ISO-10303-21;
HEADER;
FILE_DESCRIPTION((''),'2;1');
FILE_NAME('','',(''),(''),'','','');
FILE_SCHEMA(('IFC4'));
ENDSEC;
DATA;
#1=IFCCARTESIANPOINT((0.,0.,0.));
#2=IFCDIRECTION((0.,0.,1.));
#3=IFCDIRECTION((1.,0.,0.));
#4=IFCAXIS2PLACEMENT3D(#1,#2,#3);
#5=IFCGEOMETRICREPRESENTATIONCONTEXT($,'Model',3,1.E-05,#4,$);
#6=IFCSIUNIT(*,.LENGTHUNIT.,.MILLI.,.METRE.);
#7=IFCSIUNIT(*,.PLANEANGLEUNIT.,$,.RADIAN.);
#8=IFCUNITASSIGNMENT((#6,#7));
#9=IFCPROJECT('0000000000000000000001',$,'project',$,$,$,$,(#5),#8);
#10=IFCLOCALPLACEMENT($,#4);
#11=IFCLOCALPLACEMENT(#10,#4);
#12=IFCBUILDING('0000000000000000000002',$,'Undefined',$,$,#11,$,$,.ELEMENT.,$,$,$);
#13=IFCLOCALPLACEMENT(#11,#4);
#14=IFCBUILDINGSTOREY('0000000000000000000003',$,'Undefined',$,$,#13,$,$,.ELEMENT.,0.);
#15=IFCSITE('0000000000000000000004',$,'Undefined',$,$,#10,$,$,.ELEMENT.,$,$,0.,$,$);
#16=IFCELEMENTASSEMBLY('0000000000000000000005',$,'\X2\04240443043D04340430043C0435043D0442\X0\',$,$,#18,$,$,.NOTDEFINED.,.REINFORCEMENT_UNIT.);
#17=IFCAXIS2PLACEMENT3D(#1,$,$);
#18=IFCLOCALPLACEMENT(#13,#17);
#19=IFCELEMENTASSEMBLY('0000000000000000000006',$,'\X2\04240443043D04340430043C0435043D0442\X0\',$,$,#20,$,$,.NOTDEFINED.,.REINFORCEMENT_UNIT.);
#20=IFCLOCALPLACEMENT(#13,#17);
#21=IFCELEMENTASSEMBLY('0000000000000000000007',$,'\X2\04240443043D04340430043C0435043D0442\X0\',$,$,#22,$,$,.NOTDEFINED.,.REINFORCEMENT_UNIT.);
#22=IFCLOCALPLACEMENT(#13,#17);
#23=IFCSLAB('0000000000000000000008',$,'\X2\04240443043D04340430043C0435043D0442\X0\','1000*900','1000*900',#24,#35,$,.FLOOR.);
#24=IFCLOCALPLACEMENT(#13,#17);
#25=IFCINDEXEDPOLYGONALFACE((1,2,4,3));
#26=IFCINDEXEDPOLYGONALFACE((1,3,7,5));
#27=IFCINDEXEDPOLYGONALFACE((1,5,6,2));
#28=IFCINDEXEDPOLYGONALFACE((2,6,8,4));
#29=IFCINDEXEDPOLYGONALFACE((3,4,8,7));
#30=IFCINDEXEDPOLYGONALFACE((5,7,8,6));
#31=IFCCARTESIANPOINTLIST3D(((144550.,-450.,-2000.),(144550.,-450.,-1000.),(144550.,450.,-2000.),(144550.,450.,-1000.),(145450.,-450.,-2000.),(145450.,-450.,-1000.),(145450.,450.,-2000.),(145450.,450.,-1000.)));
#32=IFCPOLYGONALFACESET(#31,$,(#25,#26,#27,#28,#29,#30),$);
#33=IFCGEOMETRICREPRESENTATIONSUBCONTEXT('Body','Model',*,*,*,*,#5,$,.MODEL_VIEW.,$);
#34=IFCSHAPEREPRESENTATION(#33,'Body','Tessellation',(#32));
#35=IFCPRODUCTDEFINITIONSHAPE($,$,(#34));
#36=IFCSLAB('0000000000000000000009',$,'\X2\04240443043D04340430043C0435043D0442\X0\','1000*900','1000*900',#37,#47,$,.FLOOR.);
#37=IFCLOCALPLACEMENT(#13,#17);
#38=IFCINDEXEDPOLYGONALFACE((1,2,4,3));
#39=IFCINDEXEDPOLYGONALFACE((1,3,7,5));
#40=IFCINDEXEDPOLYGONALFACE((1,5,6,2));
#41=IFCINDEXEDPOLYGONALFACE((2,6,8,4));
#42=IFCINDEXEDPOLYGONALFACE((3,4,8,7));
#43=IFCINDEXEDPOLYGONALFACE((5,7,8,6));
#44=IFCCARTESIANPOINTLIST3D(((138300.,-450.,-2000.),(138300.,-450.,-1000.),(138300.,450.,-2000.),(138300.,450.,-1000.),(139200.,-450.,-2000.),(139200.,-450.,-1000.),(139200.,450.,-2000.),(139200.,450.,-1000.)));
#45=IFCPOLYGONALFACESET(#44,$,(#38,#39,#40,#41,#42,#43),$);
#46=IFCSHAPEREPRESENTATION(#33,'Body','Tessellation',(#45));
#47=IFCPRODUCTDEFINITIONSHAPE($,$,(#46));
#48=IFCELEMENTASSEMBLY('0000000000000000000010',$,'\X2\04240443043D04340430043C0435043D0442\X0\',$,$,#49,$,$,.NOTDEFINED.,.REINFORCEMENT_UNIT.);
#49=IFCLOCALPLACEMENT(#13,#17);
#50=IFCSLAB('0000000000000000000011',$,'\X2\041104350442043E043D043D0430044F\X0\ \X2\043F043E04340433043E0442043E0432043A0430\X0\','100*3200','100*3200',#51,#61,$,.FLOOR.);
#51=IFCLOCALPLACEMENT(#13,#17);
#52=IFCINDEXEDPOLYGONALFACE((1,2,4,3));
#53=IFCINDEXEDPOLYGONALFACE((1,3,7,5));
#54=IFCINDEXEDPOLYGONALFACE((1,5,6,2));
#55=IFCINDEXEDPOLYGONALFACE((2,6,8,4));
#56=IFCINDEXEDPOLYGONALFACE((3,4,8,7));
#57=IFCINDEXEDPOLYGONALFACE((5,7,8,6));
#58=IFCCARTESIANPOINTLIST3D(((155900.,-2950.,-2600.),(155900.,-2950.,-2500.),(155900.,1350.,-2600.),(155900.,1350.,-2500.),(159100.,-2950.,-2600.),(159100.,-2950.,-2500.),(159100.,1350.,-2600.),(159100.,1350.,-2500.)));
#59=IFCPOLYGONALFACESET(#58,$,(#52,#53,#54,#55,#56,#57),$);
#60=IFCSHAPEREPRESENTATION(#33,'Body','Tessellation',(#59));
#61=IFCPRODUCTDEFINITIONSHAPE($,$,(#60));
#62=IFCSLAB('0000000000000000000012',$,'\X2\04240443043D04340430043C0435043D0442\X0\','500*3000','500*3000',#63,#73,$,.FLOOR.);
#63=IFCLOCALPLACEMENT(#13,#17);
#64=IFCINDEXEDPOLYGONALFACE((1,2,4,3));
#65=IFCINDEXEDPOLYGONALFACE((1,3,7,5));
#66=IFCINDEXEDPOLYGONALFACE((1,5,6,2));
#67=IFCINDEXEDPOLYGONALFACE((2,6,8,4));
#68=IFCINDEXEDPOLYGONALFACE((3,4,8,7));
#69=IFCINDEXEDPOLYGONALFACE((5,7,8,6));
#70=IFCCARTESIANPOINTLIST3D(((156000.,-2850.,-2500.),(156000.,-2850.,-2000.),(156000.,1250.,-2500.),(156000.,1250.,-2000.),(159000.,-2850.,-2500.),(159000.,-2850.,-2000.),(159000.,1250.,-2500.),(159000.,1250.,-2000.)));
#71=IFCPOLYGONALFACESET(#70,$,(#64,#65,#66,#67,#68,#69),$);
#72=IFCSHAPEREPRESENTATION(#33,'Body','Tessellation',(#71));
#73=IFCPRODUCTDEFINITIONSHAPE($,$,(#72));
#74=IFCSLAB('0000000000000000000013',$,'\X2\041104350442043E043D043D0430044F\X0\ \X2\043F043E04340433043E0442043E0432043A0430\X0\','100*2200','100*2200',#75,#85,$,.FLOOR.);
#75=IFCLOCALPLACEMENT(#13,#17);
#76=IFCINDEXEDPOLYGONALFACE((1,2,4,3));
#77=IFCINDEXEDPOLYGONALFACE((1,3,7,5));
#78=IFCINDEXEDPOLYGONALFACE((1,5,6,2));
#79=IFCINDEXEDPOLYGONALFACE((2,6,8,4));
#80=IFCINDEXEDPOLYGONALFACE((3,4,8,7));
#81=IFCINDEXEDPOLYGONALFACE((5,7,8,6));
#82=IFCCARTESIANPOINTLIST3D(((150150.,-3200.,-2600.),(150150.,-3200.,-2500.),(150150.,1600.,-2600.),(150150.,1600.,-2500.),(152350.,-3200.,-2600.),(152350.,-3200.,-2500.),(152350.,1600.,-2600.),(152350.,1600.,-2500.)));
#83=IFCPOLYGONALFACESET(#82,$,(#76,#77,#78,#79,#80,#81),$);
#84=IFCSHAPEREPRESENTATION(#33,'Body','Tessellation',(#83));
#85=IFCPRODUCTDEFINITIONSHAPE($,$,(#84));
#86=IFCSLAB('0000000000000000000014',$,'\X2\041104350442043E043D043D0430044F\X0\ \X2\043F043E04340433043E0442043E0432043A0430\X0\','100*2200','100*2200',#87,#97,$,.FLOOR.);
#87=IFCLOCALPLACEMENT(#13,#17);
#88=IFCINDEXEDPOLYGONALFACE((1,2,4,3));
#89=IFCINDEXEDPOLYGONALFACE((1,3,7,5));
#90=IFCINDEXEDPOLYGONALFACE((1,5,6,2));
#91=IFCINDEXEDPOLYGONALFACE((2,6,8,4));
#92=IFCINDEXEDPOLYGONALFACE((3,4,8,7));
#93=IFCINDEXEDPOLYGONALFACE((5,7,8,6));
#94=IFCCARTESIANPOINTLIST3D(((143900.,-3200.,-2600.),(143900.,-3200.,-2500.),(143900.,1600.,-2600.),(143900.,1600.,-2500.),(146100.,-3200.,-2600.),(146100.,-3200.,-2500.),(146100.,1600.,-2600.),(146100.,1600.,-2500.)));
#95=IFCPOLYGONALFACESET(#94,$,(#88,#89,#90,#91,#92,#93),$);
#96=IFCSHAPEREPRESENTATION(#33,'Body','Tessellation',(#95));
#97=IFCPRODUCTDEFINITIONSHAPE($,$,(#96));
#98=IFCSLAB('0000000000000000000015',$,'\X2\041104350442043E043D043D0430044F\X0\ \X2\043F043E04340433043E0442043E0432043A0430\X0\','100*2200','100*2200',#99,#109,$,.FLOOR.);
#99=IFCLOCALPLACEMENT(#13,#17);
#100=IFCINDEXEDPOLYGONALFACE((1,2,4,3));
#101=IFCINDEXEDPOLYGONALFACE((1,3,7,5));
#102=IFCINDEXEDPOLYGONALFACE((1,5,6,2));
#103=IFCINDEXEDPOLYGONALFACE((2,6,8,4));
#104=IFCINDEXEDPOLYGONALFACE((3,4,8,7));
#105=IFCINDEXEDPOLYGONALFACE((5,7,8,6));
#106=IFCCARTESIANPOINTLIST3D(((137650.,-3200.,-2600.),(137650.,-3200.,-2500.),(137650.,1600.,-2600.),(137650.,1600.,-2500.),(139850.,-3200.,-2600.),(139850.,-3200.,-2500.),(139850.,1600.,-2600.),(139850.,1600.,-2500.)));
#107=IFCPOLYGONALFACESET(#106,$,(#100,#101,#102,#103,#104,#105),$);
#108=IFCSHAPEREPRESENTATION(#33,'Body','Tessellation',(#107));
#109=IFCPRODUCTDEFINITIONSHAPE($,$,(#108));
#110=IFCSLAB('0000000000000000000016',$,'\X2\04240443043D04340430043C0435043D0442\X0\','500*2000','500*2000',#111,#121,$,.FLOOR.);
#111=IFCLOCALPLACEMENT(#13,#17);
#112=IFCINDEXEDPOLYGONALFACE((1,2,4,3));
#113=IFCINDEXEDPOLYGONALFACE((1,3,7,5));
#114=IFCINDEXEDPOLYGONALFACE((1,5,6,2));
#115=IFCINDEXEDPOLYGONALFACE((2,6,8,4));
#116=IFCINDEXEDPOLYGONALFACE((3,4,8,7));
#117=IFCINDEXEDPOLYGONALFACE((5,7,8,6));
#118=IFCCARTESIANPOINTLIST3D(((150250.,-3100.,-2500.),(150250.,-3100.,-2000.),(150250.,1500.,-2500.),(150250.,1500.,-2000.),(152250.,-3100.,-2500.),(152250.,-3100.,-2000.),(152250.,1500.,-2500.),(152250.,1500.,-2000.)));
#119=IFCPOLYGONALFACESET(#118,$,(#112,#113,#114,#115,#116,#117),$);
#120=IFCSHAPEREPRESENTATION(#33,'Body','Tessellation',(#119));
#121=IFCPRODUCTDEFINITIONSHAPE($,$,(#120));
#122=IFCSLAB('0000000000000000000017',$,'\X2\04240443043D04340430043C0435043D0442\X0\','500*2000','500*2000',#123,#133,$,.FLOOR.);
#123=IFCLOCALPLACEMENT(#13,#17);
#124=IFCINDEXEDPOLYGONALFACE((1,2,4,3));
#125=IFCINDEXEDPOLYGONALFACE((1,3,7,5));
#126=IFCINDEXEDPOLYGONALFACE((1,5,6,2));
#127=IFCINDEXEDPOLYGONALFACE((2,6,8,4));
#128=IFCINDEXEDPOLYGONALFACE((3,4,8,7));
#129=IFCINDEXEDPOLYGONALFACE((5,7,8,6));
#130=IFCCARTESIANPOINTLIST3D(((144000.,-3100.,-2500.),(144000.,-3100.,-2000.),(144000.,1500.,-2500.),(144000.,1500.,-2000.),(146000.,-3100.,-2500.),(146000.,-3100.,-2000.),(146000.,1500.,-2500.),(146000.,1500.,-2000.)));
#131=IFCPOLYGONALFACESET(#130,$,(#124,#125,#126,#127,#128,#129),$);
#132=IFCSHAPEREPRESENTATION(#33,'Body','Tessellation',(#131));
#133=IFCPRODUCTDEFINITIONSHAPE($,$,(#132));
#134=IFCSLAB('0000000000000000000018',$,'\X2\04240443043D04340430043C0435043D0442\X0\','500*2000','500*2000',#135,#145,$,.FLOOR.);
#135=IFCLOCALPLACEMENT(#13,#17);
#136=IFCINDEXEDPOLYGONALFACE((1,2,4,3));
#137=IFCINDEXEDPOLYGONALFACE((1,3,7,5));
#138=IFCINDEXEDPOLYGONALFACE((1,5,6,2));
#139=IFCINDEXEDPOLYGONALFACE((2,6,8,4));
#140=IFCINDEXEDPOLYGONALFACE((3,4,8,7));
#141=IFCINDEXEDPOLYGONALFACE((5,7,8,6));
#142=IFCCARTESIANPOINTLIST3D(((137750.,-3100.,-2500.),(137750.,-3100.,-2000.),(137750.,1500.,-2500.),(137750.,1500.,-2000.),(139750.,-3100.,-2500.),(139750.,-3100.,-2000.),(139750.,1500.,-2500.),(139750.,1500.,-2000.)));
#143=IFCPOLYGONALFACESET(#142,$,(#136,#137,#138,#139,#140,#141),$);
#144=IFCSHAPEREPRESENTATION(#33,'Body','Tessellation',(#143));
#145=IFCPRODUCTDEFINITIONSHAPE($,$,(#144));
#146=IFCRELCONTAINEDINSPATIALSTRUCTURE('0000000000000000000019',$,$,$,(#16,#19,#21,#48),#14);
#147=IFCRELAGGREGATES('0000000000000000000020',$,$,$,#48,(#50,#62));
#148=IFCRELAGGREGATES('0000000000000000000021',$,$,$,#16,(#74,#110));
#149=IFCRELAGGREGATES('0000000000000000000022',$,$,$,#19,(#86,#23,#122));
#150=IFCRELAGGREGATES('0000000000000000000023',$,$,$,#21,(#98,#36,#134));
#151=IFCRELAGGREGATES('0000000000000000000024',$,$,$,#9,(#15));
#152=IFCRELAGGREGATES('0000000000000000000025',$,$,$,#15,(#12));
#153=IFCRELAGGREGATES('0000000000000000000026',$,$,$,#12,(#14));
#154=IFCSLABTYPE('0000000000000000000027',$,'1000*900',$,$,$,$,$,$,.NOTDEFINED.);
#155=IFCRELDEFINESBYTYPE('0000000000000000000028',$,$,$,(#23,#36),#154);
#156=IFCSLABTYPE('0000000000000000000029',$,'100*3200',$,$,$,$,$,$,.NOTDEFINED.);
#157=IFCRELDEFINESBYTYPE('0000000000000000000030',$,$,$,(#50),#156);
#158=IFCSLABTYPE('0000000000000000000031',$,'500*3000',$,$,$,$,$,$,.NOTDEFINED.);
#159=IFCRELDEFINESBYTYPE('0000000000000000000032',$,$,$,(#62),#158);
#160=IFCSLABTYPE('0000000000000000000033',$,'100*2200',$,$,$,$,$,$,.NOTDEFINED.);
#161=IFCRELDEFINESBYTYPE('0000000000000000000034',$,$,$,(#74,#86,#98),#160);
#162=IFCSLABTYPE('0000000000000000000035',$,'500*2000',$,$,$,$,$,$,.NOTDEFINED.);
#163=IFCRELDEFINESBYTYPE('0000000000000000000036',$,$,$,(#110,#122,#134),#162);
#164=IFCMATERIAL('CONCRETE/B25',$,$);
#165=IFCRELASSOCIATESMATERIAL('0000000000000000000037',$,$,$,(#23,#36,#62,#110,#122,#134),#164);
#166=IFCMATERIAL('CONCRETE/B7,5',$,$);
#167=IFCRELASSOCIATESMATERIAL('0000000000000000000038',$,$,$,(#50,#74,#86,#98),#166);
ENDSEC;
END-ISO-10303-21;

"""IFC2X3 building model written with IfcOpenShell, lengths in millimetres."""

from ifc_helpers import new_model, si_unit, frame, origin_with_axes, place, context, subcontext, project, spatial, polyline, outline, extrude, material, type_object, element, aggregate, save


model = new_model("IFC2X3")

# Units and contexts
model_context = context("Model", 3, precision=1e-05, world=origin_with_axes())
body_context = subcontext(model_context, "Body", "Model", "MODEL_VIEW")
ifc_project = project(units=[si_unit("LENGTHUNIT", "METRE", prefix="MILLI"), si_unit("PLANEANGLEUNIT", "RADIAN")], contexts=[model_context])

# Site, building, storey
site_placement = place(None, origin_with_axes())
site = spatial("IfcSite", under=ifc_project, at=site_placement, Name="Undefined", CompositionType="ELEMENT", RefElevation=0.0)
building_placement = place(site_placement, origin_with_axes())
building = spatial("IfcBuilding", under=site, at=building_placement, Name="Undefined", CompositionType="ELEMENT")
storey_placement = place(building_placement, origin_with_axes())
storey = spatial("IfcBuildingStorey", under=building, at=storey_placement, Name="Undefined", CompositionType="ELEMENT", Elevation=0.0)

# Element assemblies
assembly_1_placement = place(storey_placement, origin_with_axes())
assembly_1 = element("IfcElementAssembly", 1, at=assembly_1_placement, inside=storey, Name="Фундамент", AssemblyPlace="NOTDEFINED", PredefinedType="REINFORCEMENT_UNIT")
ifc_material_1 = material(Name="CONCRETE/B25")
assembly_2_placement = place(storey_placement, origin_with_axes())
assembly_2 = element("IfcElementAssembly", 2, at=assembly_2_placement, inside=storey, Name="Фундамент", AssemblyPlace="NOTDEFINED", PredefinedType="REINFORCEMENT_UNIT")
assembly_3_placement = place(storey_placement, origin_with_axes())
assembly_3 = element("IfcElementAssembly", 3, at=assembly_3_placement, inside=storey, Name="Фундамент", AssemblyPlace="NOTDEFINED", PredefinedType="REINFORCEMENT_UNIT")

# Slabs
slab_type_1 = type_object("IfcSlabType", Name="1000*900", PredefinedType="NOTDEFINED")
slab_1_placement = place(assembly_2_placement, frame((144550.0, 450.0, -1500.0), z_axis=(0.0, 0.0, 1.0), x_axis=(0.0, -1.0, 0.0)))
slab_1 = element("IfcSlab", 4, at=slab_1_placement, type_object=slab_type_1, material=ifc_material_1, Name="Фундамент", Description="1000*900", ObjectType="1000*900", PredefinedType="FLOOR", context=body_context, shape_type="SweptSolid", body=[
    extrude(outline(polyline([(0.0, 0.0), (900.0, 0.0), (900.0, 900.0), (0.0, 900.0), (0.0, 0.0)])), frame((0.0, 0.0, -500.0), z_axis=(0.0, 0.0, 1.0), x_axis=(1.0, 0.0, 0.0)), (0.0, 0.0, 1.0), 1000.0),
])
slab_2_placement = place(assembly_3_placement, frame((138300.0, 450.0, -1500.0), z_axis=(0.0, 0.0, 1.0), x_axis=(0.0, -1.0, 0.0)))
slab_2 = element("IfcSlab", 5, at=slab_2_placement, type_object=slab_type_1, material=ifc_material_1, Name="Фундамент", Description="1000*900", ObjectType="1000*900", PredefinedType="FLOOR", context=body_context, shape_type="SweptSolid", body=[
    extrude(outline(polyline([(0.0, 0.0), (900.0, 0.0), (900.0, 900.0), (0.0, 900.0), (0.0, 0.0)])), frame((0.0, 0.0, -500.0), z_axis=(0.0, 0.0, 1.0), x_axis=(1.0, 0.0, 0.0)), (0.0, 0.0, 1.0), 1000.0),
])

# Element assembly, slabs
assembly_4_placement = place(storey_placement, origin_with_axes())
assembly_4 = element("IfcElementAssembly", 6, at=assembly_4_placement, inside=storey, Name="Фундамент", AssemblyPlace="NOTDEFINED", PredefinedType="REINFORCEMENT_UNIT")
ifc_material_2 = material(Name="CONCRETE/B7,5")
slab_type_2 = type_object("IfcSlabType", Name="100*3200", PredefinedType="NOTDEFINED")
slab_3_placement = place(assembly_4_placement, frame((155900.0, 1350.0, -2550.0), z_axis=(0.0, 0.0, 1.0), x_axis=(0.0, -1.0, 0.0)))
slab_3 = element("IfcSlab", 7, at=slab_3_placement, type_object=slab_type_2, material=ifc_material_2, Name="Бетонная подготовка", Description="100*3200", ObjectType="100*3200", PredefinedType="FLOOR", context=body_context, shape_type="SweptSolid", body=[
    extrude(outline(polyline([(0.0, 0.0), (4300.0, 0.0), (4300.0, 3200.0), (0.0, 3200.0), (0.0, 0.0)])), frame((0.0, 0.0, -50.0), z_axis=(0.0, 0.0, 1.0), x_axis=(1.0, 0.0, 0.0)), (0.0, 0.0, 1.0), 100.0),
])
slab_type_3 = type_object("IfcSlabType", Name="500*3000", PredefinedType="NOTDEFINED")
slab_4_placement = place(assembly_4_placement, frame((156000.0, 1250.0, -2250.0), z_axis=(0.0, 0.0, 1.0), x_axis=(0.0, -1.0, 0.0)))
slab_4 = element("IfcSlab", 8, at=slab_4_placement, type_object=slab_type_3, material=ifc_material_1, Name="Фундамент", Description="500*3000", ObjectType="500*3000", PredefinedType="FLOOR", context=body_context, shape_type="SweptSolid", body=[
    extrude(outline(polyline([(0.0, 0.0), (4100.0, 0.0), (4100.0, 3000.0), (0.0, 3000.0), (0.0, 0.0)])), frame((0.0, 0.0, -250.0), z_axis=(0.0, 0.0, 1.0), x_axis=(1.0, 0.0, 0.0)), (0.0, 0.0, 1.0), 500.0),
])
aggregate(assembly_4, [slab_3, slab_4])

# Slabs
slab_type_4 = type_object("IfcSlabType", Name="100*2200", PredefinedType="NOTDEFINED")
slab_5_placement = place(assembly_1_placement, frame((150150.0, 1600.0, -2550.0), z_axis=(0.0, 0.0, 1.0), x_axis=(0.0, -1.0, 0.0)))
slab_5 = element("IfcSlab", 9, at=slab_5_placement, type_object=slab_type_4, material=ifc_material_2, Name="Бетонная подготовка", Description="100*2200", ObjectType="100*2200", PredefinedType="FLOOR", context=body_context, shape_type="SweptSolid", body=[
    extrude(outline(polyline([(0.0, 0.0), (4800.0, 0.0), (4800.0, 2200.0), (0.0, 2200.0), (0.0, 0.0)])), frame((0.0, 0.0, -50.0), z_axis=(0.0, 0.0, 1.0), x_axis=(1.0, 0.0, 0.0)), (0.0, 0.0, 1.0), 100.0),
])
slab_6_placement = place(assembly_2_placement, frame((143900.0, 1600.0, -2550.0), z_axis=(0.0, 0.0, 1.0), x_axis=(0.0, -1.0, 0.0)))
slab_6 = element("IfcSlab", 10, at=slab_6_placement, type_object=slab_type_4, material=ifc_material_2, Name="Бетонная подготовка", Description="100*2200", ObjectType="100*2200", PredefinedType="FLOOR", context=body_context, shape_type="SweptSolid", body=[
    extrude(outline(polyline([(0.0, 0.0), (4800.0, 0.0), (4800.0, 2200.0), (0.0, 2200.0), (0.0, 0.0)])), frame((0.0, 0.0, -50.0), z_axis=(0.0, 0.0, 1.0), x_axis=(1.0, 0.0, 0.0)), (0.0, 0.0, 1.0), 100.0),
])
slab_7_placement = place(assembly_3_placement, frame((137650.0, 1600.0, -2550.0), z_axis=(0.0, 0.0, 1.0), x_axis=(0.0, -1.0, 0.0)))
slab_7 = element("IfcSlab", 11, at=slab_7_placement, type_object=slab_type_4, material=ifc_material_2, Name="Бетонная подготовка", Description="100*2200", ObjectType="100*2200", PredefinedType="FLOOR", context=body_context, shape_type="SweptSolid", body=[
    extrude(outline(polyline([(0.0, 0.0), (4800.0, 0.0), (4800.0, 2200.0), (0.0, 2200.0), (0.0, 0.0)])), frame((0.0, 0.0, -50.0), z_axis=(0.0, 0.0, 1.0), x_axis=(1.0, 0.0, 0.0)), (0.0, 0.0, 1.0), 100.0),
])
slab_type_5 = type_object("IfcSlabType", Name="500*2000", PredefinedType="NOTDEFINED")
slab_8_placement = place(assembly_1_placement, frame((150250.0, 1500.0, -2250.0), z_axis=(0.0, 0.0, 1.0), x_axis=(0.0, -1.0, 0.0)))
slab_8 = element("IfcSlab", 12, at=slab_8_placement, type_object=slab_type_5, material=ifc_material_1, Name="Фундамент", Description="500*2000", ObjectType="500*2000", PredefinedType="FLOOR", context=body_context, shape_type="SweptSolid", body=[
    extrude(outline(polyline([(0.0, 0.0), (4600.0, 0.0), (4600.0, 2000.0), (0.0, 2000.0), (0.0, 0.0)])), frame((0.0, 0.0, -250.0), z_axis=(0.0, 0.0, 1.0), x_axis=(1.0, 0.0, 0.0)), (0.0, 0.0, 1.0), 500.0),
])
aggregate(assembly_1, [slab_5, slab_8])
slab_9_placement = place(assembly_2_placement, frame((144000.0, 1500.0, -2250.0), z_axis=(0.0, 0.0, 1.0), x_axis=(0.0, -1.0, 0.0)))
slab_9 = element("IfcSlab", 13, at=slab_9_placement, type_object=slab_type_5, material=ifc_material_1, Name="Фундамент", Description="500*2000", ObjectType="500*2000", PredefinedType="FLOOR", context=body_context, shape_type="SweptSolid", body=[
    extrude(outline(polyline([(0.0, 0.0), (4600.0, 0.0), (4600.0, 2000.0), (0.0, 2000.0), (0.0, 0.0)])), frame((0.0, 0.0, -250.0), z_axis=(0.0, 0.0, 1.0), x_axis=(1.0, 0.0, 0.0)), (0.0, 0.0, 1.0), 500.0),
])
aggregate(assembly_2, [slab_6, slab_1, slab_9])
slab_10_placement = place(assembly_3_placement, frame((137750.0, 1500.0, -2250.0), z_axis=(0.0, 0.0, 1.0), x_axis=(0.0, -1.0, 0.0)))
slab_10 = element("IfcSlab", 14, at=slab_10_placement, type_object=slab_type_5, material=ifc_material_1, Name="Фундамент", Description="500*2000", ObjectType="500*2000", PredefinedType="FLOOR", context=body_context, shape_type="SweptSolid", body=[
    extrude(outline(polyline([(0.0, 0.0), (4600.0, 0.0), (4600.0, 2000.0), (0.0, 2000.0), (0.0, 0.0)])), frame((0.0, 0.0, -250.0), z_axis=(0.0, 0.0, 1.0), x_axis=(1.0, 0.0, 0.0)), (0.0, 0.0, 1.0), 500.0),
])
aggregate(assembly_3, [slab_7, slab_2, slab_10])

save(model, "model.ifc")
